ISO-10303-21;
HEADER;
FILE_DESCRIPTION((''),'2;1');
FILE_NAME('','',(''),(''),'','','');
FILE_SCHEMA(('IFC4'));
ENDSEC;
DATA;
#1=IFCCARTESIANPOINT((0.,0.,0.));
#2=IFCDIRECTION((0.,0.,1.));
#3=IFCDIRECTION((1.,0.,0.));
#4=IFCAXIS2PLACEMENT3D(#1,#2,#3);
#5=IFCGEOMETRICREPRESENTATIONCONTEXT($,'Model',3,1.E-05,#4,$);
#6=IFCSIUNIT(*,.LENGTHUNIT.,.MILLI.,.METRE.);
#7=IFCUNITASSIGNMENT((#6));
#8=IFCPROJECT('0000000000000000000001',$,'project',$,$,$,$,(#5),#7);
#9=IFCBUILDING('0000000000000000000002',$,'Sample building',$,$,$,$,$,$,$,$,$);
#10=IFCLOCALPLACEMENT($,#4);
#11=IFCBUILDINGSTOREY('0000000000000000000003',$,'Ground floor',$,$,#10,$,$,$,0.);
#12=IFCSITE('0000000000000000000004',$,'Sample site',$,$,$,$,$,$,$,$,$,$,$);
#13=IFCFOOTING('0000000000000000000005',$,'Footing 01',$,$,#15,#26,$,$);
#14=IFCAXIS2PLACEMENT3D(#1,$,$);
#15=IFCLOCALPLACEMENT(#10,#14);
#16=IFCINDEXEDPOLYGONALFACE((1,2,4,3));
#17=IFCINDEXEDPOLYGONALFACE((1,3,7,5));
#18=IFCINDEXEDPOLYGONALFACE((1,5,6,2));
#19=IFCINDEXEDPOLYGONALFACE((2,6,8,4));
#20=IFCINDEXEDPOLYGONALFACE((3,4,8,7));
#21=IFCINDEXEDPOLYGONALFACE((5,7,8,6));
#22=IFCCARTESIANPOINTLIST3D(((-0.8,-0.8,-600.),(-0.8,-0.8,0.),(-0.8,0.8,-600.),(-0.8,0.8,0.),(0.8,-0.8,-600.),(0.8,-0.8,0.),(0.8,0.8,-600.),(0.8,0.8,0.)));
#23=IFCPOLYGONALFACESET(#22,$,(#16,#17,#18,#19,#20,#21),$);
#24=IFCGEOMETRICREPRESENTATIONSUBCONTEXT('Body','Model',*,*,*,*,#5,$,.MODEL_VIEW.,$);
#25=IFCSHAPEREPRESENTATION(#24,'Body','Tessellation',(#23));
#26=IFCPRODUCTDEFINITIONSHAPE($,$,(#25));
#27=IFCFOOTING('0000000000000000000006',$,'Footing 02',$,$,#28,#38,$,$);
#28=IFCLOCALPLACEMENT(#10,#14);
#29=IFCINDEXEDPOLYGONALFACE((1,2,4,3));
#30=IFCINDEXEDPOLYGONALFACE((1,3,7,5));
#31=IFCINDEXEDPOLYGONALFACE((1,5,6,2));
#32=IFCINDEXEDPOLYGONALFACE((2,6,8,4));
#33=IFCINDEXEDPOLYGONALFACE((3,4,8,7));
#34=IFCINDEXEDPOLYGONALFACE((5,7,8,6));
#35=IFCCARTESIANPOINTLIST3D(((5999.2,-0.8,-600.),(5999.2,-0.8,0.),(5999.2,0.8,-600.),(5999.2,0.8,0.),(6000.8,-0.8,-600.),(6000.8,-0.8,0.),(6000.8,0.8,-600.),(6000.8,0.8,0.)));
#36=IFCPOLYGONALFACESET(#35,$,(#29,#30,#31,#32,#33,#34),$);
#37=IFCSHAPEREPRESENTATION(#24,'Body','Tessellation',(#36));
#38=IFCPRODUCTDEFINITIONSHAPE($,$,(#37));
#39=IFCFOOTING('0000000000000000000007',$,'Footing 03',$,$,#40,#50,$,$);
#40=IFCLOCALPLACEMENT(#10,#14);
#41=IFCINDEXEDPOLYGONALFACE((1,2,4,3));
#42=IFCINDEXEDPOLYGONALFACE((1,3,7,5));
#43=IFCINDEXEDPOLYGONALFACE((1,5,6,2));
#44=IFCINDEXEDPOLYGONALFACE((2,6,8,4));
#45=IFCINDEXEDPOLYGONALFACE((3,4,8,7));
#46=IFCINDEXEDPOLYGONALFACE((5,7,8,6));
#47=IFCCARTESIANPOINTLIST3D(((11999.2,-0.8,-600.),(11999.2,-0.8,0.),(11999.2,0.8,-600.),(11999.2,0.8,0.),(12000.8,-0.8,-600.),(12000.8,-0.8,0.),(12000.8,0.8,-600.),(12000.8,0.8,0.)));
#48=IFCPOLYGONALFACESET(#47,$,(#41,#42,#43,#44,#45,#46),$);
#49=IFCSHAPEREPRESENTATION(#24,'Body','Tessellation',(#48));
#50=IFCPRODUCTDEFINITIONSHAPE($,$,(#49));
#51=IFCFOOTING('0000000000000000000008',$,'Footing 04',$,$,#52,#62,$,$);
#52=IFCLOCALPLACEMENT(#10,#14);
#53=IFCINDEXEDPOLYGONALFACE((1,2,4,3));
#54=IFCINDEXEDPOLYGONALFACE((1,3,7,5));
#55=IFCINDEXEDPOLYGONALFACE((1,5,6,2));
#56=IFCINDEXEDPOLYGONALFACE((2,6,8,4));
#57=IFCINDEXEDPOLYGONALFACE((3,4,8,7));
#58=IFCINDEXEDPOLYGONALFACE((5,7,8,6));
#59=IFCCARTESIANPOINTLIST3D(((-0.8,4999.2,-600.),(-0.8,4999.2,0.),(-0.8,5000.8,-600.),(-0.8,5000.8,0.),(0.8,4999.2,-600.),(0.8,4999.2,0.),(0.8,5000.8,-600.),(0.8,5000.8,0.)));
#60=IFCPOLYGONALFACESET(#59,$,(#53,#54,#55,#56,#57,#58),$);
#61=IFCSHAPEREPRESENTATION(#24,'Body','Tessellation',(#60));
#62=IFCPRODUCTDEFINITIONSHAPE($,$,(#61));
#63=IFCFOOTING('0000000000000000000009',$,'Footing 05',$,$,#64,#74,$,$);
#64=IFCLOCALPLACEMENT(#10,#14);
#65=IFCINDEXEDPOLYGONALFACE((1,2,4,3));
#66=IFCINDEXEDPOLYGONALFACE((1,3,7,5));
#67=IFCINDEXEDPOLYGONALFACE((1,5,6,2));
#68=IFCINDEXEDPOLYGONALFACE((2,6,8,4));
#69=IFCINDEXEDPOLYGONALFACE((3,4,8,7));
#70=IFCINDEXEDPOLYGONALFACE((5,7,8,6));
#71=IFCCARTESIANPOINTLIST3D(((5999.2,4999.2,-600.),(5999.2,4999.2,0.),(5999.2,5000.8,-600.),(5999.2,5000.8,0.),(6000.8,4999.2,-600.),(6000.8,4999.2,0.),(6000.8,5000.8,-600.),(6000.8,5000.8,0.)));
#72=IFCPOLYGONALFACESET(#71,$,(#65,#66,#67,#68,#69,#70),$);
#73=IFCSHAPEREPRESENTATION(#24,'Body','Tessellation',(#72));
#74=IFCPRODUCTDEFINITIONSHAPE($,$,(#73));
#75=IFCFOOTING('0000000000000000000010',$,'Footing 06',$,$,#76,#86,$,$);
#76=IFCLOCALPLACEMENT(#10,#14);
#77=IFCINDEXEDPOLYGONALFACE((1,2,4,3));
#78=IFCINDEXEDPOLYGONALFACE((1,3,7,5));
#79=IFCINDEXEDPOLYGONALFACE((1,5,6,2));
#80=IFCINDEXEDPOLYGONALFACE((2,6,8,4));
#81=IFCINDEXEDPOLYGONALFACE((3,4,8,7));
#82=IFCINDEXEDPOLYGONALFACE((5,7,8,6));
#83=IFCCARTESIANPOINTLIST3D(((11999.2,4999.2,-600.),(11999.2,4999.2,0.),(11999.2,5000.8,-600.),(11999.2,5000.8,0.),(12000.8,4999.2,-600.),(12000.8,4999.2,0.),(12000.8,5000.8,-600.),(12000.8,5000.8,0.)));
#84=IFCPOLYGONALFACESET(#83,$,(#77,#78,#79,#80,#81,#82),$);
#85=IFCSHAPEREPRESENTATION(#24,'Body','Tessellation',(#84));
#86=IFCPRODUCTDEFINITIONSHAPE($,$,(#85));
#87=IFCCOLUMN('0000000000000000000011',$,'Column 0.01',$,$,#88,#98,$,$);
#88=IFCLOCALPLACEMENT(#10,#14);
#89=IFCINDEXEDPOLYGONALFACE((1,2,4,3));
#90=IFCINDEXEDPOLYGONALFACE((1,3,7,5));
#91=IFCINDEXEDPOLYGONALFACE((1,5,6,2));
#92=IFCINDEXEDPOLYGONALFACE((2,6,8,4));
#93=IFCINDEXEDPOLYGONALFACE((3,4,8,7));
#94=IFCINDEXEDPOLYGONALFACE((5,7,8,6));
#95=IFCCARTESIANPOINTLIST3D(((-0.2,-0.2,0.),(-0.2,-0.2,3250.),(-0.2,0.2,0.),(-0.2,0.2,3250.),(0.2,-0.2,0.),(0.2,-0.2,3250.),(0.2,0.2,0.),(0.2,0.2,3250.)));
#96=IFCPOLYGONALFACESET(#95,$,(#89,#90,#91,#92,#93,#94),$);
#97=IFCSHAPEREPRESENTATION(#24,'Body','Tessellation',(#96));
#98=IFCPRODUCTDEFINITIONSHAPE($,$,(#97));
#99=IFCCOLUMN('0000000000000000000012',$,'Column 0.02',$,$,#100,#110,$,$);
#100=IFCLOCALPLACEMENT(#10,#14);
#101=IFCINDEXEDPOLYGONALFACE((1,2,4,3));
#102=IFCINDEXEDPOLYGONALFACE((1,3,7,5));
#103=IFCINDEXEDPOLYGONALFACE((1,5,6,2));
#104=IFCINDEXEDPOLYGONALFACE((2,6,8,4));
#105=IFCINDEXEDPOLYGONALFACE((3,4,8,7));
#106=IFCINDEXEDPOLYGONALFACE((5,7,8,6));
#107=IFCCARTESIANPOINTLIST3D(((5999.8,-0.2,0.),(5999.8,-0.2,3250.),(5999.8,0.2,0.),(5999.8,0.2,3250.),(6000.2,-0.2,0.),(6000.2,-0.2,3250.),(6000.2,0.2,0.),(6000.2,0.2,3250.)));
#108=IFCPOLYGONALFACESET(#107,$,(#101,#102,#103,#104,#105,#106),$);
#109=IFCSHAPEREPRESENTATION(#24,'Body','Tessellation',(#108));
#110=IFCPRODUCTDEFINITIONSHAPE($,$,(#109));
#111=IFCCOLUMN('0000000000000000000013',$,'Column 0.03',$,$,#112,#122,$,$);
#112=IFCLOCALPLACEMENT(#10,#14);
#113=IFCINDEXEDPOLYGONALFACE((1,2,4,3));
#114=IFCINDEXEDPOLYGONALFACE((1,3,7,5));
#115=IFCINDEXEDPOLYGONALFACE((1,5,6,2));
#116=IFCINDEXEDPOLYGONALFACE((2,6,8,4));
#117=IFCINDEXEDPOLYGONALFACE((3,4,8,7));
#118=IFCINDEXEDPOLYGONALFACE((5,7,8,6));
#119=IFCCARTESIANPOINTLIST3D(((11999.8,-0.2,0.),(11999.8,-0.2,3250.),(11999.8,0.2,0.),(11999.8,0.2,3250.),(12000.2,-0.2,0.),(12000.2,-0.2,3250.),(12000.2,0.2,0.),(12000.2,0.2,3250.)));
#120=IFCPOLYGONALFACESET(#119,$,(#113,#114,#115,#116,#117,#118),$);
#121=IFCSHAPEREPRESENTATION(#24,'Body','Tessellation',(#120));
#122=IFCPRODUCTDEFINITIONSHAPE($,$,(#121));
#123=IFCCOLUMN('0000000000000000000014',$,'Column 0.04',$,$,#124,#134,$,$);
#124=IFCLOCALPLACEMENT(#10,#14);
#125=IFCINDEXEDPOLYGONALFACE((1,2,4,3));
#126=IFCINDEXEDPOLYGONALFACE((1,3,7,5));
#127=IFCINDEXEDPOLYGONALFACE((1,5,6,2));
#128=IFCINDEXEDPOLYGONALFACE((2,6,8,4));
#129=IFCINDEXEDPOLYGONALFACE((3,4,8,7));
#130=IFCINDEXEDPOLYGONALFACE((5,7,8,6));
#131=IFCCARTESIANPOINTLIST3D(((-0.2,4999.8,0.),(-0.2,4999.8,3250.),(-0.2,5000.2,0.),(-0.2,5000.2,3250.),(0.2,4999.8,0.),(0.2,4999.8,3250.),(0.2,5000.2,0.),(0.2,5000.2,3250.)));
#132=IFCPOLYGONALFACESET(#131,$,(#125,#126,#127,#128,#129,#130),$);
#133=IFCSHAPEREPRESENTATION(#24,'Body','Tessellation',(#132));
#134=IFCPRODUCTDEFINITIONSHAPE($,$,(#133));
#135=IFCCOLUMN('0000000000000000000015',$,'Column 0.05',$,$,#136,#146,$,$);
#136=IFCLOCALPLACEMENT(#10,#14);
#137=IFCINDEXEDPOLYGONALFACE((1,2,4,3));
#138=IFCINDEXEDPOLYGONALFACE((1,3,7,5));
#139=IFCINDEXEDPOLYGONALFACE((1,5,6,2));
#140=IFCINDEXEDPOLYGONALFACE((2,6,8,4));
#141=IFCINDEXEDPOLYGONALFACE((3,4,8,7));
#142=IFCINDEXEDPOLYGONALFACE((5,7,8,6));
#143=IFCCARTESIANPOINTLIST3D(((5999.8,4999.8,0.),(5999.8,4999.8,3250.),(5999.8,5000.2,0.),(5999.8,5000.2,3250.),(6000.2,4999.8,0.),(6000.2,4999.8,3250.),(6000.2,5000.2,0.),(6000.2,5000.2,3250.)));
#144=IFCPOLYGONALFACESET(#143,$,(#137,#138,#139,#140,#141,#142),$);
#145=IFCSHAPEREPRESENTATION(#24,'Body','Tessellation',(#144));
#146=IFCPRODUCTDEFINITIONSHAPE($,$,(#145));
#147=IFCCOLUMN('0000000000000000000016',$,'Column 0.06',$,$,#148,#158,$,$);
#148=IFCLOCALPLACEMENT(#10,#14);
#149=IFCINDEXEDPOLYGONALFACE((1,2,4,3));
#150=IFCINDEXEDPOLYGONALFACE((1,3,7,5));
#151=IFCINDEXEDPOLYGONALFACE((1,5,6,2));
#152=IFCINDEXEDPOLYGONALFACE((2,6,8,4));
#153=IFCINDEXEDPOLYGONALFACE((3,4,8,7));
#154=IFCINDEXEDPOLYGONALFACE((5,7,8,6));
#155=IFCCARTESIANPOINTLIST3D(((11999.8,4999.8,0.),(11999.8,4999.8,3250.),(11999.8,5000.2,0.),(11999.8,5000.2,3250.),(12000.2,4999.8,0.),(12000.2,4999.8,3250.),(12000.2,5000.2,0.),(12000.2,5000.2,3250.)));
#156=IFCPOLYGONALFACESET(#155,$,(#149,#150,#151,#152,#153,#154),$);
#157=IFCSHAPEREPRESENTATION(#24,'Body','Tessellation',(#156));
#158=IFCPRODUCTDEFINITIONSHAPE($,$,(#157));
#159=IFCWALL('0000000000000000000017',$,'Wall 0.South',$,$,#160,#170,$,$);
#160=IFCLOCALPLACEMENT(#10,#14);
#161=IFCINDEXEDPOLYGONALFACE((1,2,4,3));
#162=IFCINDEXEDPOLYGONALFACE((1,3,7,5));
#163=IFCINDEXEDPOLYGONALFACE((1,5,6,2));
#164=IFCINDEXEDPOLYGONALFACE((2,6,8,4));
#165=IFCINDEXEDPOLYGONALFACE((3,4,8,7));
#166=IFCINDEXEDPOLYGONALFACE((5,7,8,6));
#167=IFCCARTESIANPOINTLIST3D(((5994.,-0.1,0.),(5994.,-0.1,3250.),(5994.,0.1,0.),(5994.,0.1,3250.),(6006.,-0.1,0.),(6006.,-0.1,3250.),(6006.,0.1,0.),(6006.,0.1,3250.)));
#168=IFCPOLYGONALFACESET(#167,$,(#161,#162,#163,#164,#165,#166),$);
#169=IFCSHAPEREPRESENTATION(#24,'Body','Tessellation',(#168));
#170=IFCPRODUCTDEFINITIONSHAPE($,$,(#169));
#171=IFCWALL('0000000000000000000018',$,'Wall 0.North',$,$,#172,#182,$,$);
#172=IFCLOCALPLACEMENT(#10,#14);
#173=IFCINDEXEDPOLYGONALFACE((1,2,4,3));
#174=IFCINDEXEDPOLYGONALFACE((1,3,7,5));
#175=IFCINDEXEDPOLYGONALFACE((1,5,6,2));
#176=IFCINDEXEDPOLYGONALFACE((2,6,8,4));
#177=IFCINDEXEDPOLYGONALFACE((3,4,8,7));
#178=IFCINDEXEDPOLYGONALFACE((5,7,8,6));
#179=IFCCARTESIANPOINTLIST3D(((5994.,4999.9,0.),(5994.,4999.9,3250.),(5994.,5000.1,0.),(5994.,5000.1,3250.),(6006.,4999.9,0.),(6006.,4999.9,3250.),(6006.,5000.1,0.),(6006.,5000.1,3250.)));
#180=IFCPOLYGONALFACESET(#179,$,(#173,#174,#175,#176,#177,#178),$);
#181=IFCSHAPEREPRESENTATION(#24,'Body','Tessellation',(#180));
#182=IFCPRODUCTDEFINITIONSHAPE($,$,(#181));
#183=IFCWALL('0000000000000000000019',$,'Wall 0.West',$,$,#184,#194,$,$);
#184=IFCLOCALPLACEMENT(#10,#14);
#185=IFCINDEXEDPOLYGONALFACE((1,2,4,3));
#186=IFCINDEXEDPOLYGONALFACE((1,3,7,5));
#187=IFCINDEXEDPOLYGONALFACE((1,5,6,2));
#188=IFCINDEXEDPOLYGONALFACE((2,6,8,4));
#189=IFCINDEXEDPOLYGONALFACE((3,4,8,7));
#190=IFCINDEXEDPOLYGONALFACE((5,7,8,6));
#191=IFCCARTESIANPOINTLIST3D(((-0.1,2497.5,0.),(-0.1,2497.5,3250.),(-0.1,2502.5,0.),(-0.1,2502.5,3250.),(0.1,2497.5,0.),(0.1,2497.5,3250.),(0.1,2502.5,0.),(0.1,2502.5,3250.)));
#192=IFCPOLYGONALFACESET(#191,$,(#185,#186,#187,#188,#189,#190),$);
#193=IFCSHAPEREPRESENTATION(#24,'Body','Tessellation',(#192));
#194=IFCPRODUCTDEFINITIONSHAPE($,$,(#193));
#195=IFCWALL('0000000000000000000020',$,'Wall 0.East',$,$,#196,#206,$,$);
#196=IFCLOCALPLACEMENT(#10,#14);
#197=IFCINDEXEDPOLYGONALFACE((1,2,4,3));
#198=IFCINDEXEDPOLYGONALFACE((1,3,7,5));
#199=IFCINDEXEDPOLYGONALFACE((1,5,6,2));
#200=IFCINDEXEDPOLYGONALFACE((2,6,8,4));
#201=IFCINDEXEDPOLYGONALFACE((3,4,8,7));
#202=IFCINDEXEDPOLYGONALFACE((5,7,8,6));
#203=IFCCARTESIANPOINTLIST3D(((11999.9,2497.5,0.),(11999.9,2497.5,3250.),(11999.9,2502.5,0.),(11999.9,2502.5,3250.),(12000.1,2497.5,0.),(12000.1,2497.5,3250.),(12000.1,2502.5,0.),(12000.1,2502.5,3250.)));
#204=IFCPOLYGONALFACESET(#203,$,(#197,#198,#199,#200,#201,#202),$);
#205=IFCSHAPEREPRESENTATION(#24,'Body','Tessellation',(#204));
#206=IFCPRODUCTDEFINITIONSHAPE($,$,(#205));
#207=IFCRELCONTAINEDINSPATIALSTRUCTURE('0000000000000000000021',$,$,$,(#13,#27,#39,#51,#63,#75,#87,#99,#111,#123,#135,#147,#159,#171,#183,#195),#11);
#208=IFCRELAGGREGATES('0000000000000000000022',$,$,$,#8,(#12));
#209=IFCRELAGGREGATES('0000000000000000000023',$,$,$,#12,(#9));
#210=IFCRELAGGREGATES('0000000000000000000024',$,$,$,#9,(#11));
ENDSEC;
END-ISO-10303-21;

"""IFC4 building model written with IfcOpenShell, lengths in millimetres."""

from ifc_helpers import new_model, si_unit, frame, origin_with_axes, origin_2d, place, context, subcontext, project, spatial, rectangle, extrude, element, save


model = new_model("IFC4")

# Units and contexts
model_context = context("Model", 3, precision=1e-05, world=origin_with_axes())
body_context = subcontext(model_context, "Body", "Model", "MODEL_VIEW")
ifc_project = project(units=[si_unit("LENGTHUNIT", "METRE", prefix="MILLI")], contexts=[model_context])

# Site, building, storey
site = spatial("IfcSite", under=ifc_project, Name="Sample site")
building = spatial("IfcBuilding", under=site, Name="Sample building")
storey_placement = place(None, origin_with_axes())
storey = spatial("IfcBuildingStorey", under=building, at=storey_placement, Name="Ground floor", Elevation=0.0)

# Footings
for number, where, z_axis, x_axis, name in (
    (1, (0.0, 0.0, -600.0), (0.0, 0.0, 1.0), (1.0, 0.0, 0.0), "Footing 01"),
    (2, (6000.0, 0.0, -600.0), (0.0, 0.0, 1.0), (1.0, 0.0, 0.0), "Footing 02"),
    (3, (12000.0, 0.0, -600.0), (0.0, 0.0, 1.0), (1.0, 0.0, 0.0), "Footing 03"),
    (4, (0.0, 5000.0, -600.0), (0.0, 0.0, 1.0), (1.0, 0.0, 0.0), "Footing 04"),
    (5, (6000.0, 5000.0, -600.0), (0.0, 0.0, 1.0), (1.0, 0.0, 0.0), "Footing 05"),
    (6, (12000.0, 5000.0, -600.0), (0.0, 0.0, 1.0), (1.0, 0.0, 0.0), "Footing 06"),
):
    element("IfcFooting", number, at=place(storey_placement, frame(where, z_axis=z_axis, x_axis=x_axis)), inside=storey, Name=name, context=body_context, shape_type="SweptSolid", body=[
        extrude(rectangle(XDim=1.6, YDim=1.6, at=origin_2d()), origin_with_axes(), (0.0, 0.0, 1.0), 600.0),
    ])

# Columns
for number, where, z_axis, x_axis, name in (
    (7, (0.0, 0.0, 0.0), (0.0, 0.0, 1.0), (1.0, 0.0, 0.0), "Column 0.01"),
    (8, (6000.0, 0.0, 0.0), (0.0, 0.0, 1.0), (1.0, 0.0, 0.0), "Column 0.02"),
    (9, (12000.0, 0.0, 0.0), (0.0, 0.0, 1.0), (1.0, 0.0, 0.0), "Column 0.03"),
    (10, (0.0, 5000.0, 0.0), (0.0, 0.0, 1.0), (1.0, 0.0, 0.0), "Column 0.04"),
    (11, (6000.0, 5000.0, 0.0), (0.0, 0.0, 1.0), (1.0, 0.0, 0.0), "Column 0.05"),
    (12, (12000.0, 5000.0, 0.0), (0.0, 0.0, 1.0), (1.0, 0.0, 0.0), "Column 0.06"),
):
    element("IfcColumn", number, at=place(storey_placement, frame(where, z_axis=z_axis, x_axis=x_axis)), inside=storey, Name=name, context=body_context, shape_type="SweptSolid", body=[
        extrude(rectangle(XDim=0.4, YDim=0.4, at=origin_2d()), origin_with_axes(), (0.0, 0.0, 1.0), 3250.0),
    ])

# Walls
for number, where, z_axis, x_axis, name in (
    (13, (6000.0, 0.0, 0.0), (0.0, 0.0, 1.0), (1.0, 0.0, 0.0), "Wall 0.South"),
    (14, (6000.0, 5000.0, 0.0), (0.0, 0.0, 1.0), (1.0, 0.0, 0.0), "Wall 0.North"),
):
    element("IfcWall", number, at=place(storey_placement, frame(where, z_axis=z_axis, x_axis=x_axis)), inside=storey, Name=name, context=body_context, shape_type="SweptSolid", body=[
        extrude(rectangle(XDim=12.0, YDim=0.2, at=origin_2d()), origin_with_axes(), (0.0, 0.0, 1.0), 3250.0),
    ])
for number, where, z_axis, x_axis, name in (
    (15, (0.0, 2500.0, 0.0), (0.0, 0.0, 1.0), (0.0, 1.0, 0.0), "Wall 0.West"),
    (16, (12000.0, 2500.0, 0.0), (0.0, 0.0, 1.0), (0.0, 1.0, 0.0), "Wall 0.East"),
):
    element("IfcWall", number, at=place(storey_placement, frame(where, z_axis=z_axis, x_axis=x_axis)), inside=storey, Name=name, context=body_context, shape_type="SweptSolid", body=[
        extrude(rectangle(XDim=5.0, YDim=0.2, at=origin_2d()), origin_with_axes(), (0.0, 0.0, 1.0), 3250.0),
    ])

save(model, "model.ifc")
